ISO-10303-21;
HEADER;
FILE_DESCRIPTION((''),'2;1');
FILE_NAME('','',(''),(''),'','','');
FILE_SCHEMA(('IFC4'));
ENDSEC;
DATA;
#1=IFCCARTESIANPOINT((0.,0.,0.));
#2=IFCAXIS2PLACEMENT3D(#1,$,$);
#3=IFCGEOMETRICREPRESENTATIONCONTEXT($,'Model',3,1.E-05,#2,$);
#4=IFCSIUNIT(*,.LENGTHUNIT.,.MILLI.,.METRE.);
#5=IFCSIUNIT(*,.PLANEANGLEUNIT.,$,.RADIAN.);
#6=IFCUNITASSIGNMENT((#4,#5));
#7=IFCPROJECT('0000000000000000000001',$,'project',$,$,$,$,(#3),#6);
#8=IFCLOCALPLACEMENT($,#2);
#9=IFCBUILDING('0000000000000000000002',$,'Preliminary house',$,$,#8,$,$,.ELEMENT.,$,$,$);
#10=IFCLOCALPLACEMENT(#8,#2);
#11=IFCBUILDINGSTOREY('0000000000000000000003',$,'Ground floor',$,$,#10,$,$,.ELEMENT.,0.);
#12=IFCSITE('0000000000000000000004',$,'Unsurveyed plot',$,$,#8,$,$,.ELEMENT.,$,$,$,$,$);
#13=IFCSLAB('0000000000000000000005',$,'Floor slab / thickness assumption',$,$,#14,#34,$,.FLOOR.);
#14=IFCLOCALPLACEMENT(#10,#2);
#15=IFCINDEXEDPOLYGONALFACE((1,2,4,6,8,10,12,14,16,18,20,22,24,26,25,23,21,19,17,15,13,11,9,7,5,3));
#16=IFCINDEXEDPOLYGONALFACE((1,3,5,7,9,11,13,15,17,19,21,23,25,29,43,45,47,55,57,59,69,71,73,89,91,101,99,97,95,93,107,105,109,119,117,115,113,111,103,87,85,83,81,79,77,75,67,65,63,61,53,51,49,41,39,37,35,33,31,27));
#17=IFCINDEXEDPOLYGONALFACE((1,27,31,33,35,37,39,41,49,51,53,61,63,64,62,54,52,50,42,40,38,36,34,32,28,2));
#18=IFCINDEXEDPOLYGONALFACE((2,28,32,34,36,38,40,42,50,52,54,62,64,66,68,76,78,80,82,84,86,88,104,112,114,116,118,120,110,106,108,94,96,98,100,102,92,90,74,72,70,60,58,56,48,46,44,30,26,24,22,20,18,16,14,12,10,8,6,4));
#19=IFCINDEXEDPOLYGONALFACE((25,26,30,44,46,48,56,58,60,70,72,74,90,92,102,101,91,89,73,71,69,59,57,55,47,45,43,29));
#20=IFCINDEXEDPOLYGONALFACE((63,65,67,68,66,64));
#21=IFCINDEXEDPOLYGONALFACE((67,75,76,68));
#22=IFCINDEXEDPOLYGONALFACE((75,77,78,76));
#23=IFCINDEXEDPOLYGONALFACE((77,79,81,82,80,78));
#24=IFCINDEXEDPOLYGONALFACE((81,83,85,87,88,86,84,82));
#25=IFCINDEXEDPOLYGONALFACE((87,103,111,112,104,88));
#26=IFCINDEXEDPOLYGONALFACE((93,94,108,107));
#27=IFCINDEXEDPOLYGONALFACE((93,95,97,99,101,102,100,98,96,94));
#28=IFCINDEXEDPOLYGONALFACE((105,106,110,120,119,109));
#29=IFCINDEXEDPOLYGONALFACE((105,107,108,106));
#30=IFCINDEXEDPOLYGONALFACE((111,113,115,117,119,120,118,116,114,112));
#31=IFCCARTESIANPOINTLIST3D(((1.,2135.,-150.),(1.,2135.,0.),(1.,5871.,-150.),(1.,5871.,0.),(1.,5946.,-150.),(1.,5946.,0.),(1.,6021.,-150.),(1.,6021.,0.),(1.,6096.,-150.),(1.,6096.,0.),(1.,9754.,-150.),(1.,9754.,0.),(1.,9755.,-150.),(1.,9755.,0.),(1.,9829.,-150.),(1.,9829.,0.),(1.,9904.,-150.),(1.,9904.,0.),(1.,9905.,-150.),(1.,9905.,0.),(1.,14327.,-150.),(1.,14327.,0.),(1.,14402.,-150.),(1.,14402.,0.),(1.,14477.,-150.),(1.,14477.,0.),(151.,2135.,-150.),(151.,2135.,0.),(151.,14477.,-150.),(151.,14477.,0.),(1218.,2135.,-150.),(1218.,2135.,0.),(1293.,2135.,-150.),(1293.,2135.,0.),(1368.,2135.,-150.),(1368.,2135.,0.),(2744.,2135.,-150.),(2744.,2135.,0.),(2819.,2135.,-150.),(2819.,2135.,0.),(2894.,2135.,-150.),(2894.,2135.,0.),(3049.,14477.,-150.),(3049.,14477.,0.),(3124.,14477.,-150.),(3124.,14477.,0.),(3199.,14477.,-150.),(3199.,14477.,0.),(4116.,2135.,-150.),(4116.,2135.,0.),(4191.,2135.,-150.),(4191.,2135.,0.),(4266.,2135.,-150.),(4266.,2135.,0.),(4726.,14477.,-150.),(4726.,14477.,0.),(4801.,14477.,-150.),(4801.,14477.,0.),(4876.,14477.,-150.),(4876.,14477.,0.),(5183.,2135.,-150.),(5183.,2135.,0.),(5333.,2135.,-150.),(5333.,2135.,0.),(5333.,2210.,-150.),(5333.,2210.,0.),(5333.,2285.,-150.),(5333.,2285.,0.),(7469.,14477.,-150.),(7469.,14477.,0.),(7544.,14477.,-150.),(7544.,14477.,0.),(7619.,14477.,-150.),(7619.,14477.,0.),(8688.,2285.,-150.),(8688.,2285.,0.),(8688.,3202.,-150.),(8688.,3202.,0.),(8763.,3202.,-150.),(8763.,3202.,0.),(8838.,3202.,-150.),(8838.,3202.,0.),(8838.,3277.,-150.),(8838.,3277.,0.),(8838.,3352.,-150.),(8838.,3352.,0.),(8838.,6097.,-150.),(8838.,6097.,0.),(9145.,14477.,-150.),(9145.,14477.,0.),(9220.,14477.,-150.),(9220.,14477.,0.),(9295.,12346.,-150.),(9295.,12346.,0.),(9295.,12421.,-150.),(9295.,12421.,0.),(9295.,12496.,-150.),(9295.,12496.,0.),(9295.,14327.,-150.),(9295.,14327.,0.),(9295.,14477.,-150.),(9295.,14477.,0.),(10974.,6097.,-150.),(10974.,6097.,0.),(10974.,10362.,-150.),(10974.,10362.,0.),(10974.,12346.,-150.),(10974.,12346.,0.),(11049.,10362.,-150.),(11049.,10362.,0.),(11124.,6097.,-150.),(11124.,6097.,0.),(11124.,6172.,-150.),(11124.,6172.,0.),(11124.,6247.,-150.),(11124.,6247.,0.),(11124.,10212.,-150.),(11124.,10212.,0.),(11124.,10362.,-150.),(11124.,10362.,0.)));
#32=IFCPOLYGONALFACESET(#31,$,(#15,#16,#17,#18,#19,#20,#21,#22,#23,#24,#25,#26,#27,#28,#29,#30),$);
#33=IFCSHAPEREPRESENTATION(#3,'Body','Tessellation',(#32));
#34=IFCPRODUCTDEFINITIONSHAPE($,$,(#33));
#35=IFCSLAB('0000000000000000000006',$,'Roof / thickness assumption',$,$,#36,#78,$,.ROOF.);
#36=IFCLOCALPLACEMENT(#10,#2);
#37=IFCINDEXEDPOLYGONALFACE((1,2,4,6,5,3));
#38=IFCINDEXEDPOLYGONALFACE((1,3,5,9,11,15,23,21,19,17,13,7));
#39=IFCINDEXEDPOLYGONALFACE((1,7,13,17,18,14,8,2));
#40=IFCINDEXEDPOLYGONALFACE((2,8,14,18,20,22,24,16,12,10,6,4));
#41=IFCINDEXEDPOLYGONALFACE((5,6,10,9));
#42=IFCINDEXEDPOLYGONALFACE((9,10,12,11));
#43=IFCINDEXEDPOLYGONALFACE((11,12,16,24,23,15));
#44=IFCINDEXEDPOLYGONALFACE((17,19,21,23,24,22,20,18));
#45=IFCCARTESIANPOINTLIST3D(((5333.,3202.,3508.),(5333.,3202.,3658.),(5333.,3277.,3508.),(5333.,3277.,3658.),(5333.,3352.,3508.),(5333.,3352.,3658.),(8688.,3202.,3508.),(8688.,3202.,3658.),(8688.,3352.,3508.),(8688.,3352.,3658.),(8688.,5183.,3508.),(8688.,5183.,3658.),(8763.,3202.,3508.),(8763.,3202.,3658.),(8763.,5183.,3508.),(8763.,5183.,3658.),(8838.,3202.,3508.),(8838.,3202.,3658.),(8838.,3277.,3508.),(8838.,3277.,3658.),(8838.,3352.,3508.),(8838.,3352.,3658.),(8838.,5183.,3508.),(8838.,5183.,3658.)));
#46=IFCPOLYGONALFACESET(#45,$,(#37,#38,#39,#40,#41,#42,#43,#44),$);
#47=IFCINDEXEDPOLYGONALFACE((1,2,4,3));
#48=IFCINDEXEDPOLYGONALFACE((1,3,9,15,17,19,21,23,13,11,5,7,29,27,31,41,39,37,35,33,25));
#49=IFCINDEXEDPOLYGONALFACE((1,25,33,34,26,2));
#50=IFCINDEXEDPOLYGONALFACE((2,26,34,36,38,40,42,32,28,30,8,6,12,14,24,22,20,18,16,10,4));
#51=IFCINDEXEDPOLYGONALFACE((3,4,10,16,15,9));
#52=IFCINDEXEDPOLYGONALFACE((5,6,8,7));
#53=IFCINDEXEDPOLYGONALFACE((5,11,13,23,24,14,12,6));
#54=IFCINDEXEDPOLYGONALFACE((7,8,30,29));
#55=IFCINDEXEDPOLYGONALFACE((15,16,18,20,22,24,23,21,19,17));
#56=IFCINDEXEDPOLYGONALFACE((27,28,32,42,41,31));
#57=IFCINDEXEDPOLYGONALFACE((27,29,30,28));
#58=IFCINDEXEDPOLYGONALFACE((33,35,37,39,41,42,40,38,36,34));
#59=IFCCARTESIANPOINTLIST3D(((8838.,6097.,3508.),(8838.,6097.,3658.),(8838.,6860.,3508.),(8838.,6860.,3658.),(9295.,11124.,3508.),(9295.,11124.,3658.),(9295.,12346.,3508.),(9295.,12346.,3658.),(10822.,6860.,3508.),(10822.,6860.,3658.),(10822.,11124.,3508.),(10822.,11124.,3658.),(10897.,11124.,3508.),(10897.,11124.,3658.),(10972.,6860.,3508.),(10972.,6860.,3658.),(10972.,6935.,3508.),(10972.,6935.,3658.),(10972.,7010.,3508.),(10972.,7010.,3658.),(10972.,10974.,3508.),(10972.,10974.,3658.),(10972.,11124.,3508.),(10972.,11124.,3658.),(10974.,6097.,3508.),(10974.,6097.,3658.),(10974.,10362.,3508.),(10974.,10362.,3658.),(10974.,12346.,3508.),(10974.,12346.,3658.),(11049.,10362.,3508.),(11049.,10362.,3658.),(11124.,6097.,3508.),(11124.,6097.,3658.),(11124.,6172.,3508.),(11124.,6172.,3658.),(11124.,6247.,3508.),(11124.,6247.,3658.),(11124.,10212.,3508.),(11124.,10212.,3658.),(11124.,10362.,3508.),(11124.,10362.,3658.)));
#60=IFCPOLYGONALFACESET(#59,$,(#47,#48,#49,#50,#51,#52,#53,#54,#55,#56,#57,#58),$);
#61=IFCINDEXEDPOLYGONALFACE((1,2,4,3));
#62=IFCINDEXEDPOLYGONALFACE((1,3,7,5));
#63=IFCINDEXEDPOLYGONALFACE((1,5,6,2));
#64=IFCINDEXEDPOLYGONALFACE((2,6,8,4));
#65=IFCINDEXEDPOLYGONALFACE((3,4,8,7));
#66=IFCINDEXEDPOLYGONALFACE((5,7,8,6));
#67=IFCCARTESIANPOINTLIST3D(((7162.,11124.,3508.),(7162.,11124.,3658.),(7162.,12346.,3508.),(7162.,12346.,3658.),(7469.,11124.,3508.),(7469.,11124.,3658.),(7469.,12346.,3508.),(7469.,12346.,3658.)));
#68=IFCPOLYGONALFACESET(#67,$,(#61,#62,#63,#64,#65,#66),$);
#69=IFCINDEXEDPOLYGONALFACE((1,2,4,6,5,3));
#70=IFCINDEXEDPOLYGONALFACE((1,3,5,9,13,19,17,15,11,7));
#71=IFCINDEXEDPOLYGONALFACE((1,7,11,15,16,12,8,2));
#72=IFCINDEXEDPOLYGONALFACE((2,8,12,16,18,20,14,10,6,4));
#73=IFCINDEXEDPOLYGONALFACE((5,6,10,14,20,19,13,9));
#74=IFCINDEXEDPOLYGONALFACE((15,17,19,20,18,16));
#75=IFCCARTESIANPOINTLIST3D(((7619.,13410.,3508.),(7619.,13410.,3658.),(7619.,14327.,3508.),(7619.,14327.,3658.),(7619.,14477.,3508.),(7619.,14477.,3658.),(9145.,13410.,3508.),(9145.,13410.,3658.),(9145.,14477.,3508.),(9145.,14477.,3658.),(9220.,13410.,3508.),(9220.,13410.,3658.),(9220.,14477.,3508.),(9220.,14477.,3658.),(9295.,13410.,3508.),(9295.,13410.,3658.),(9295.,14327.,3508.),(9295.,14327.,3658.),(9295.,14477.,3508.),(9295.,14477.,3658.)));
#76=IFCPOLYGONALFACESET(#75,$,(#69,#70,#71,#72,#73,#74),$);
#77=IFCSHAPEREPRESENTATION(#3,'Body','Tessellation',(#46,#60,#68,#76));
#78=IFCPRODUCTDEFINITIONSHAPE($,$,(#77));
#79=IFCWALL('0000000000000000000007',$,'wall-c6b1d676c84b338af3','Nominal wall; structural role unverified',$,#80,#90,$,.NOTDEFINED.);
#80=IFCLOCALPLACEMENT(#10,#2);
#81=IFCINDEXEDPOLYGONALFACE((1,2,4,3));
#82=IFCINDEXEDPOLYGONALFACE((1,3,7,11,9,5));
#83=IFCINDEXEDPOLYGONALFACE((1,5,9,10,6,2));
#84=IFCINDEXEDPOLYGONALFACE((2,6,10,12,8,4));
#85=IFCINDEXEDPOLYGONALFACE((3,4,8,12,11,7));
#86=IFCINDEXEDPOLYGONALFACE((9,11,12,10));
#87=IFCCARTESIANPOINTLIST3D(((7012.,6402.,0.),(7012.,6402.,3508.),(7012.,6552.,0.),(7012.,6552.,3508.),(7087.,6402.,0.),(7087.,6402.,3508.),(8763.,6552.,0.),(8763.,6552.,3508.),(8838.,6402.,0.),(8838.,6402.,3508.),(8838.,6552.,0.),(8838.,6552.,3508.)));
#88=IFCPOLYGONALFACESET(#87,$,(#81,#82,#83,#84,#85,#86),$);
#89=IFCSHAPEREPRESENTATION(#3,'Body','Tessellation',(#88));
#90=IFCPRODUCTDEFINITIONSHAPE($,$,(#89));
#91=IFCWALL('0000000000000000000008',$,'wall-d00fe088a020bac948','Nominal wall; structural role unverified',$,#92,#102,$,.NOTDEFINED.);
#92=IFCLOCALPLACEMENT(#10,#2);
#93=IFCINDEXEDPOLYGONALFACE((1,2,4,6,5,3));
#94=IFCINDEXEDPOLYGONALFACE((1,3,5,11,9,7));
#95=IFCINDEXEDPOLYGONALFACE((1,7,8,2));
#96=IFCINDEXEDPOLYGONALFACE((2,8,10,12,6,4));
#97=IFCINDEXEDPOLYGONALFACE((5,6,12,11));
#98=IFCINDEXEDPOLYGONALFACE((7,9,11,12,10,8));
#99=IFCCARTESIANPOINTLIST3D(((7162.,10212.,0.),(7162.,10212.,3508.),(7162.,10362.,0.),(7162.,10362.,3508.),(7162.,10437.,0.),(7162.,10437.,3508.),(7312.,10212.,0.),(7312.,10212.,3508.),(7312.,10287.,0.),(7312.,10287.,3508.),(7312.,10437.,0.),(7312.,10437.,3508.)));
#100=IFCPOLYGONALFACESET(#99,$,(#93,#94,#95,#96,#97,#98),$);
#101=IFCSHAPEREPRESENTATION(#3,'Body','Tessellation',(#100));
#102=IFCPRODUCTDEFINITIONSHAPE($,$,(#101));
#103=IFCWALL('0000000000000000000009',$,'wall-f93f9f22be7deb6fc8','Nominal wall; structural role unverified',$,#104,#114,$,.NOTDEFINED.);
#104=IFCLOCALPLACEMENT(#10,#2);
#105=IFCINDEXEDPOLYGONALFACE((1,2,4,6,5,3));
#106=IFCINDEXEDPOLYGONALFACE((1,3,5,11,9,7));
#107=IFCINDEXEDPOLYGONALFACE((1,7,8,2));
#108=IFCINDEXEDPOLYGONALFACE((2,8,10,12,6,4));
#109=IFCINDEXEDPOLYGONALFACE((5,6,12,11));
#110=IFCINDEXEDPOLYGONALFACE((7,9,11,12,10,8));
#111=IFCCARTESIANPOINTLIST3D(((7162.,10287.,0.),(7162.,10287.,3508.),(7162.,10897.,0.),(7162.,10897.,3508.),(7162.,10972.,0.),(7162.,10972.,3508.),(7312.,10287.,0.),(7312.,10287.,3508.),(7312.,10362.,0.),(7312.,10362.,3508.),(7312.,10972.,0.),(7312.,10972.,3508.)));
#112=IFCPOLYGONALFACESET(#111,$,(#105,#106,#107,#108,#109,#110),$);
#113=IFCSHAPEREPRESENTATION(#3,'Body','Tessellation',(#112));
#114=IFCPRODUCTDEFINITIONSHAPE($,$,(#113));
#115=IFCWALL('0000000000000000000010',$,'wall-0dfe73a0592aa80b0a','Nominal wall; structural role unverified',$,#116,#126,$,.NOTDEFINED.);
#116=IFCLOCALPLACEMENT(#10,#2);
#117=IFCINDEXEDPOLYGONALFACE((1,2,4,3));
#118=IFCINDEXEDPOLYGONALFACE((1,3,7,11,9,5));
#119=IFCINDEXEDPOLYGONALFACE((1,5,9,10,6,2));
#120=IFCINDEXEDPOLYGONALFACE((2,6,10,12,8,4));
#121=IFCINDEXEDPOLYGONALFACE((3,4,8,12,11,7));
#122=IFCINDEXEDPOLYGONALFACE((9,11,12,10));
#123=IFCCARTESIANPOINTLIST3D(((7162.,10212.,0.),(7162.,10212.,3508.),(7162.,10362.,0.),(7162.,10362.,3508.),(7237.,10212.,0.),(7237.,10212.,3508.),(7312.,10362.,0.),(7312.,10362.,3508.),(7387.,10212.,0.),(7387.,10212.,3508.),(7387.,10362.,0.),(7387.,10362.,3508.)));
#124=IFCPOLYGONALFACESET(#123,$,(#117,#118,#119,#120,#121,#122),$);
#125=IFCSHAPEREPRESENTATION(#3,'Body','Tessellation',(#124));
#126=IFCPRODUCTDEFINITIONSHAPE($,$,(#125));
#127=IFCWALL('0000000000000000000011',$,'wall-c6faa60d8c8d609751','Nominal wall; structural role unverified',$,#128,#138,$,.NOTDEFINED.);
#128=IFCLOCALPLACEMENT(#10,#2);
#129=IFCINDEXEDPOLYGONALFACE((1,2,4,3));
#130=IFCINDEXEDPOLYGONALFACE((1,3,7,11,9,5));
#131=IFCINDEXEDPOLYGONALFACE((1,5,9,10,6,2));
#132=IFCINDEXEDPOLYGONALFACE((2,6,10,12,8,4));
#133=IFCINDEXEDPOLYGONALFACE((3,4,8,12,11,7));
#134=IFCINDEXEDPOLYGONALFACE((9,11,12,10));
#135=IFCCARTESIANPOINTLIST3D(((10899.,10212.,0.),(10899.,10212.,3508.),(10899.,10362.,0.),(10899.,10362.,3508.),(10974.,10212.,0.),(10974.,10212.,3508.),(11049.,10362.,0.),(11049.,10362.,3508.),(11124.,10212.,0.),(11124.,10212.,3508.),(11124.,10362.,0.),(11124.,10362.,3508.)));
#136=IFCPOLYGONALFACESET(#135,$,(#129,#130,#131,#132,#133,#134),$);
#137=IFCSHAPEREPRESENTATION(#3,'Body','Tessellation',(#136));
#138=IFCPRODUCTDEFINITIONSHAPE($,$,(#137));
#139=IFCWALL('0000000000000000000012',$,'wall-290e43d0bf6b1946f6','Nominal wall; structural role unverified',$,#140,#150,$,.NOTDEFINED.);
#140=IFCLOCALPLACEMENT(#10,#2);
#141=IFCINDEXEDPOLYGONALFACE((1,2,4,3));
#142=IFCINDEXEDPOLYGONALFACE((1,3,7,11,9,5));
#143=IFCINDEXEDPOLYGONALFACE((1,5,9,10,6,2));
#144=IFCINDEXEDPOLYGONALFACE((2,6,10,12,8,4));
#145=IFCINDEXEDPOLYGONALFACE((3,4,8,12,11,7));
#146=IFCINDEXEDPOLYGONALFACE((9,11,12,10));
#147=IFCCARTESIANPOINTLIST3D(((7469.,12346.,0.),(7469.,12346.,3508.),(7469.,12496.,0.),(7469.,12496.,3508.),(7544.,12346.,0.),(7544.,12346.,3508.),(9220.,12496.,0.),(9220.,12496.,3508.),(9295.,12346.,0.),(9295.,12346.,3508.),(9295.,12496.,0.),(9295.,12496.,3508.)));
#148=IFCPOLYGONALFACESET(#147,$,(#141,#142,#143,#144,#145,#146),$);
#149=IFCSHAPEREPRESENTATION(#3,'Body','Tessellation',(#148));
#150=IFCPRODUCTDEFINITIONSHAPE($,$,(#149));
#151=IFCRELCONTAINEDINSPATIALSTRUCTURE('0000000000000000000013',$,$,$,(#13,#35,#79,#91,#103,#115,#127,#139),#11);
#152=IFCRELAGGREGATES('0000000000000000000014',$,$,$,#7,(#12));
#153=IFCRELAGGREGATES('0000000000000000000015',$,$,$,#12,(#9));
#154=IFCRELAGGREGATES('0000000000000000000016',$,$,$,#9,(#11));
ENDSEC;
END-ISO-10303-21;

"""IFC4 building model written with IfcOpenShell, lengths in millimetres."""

from ifc_helpers import new_model, si_unit, frame, origin, place, context, project, spatial, polyline, outline, extrude, element, save


model = new_model("IFC4")

# Units and contexts
model_context = context("Model", 3, precision=1e-05, world=origin())
ifc_project = project(units=[si_unit("LENGTHUNIT", "METRE", prefix="MILLI"), si_unit("PLANEANGLEUNIT", "RADIAN")], contexts=[model_context])

# Site, building, storey
placement_1 = place(None, origin())
site = spatial("IfcSite", under=ifc_project, at=placement_1, Name="Unsurveyed plot", CompositionType="ELEMENT")
building = spatial("IfcBuilding", under=site, at=placement_1, Name="Preliminary house", CompositionType="ELEMENT")
placement_2 = place(placement_1, origin())
storey = spatial("IfcBuildingStorey", under=building, at=placement_2, Name="Ground floor", CompositionType="ELEMENT", Elevation=0.0)

# Slabs
element("IfcSlab", 1, at=placement_2, inside=storey, Name="Floor slab / thickness assumption", PredefinedType="FLOOR", context=model_context, shape_type="SweptSolid", body=[
    extrude(outline(polyline([(1368.0, 2135.0), (1293.0, 2135.0), (1218.0, 2135.0), (151.0, 2135.0), (1.0, 2135.0), (1.0, 5871.0), (1.0, 5946.0), (1.0, 6021.0), (1.0, 6096.0), (1.0, 9754.0), (1.0, 9755.0), (1.0, 9829.0), (1.0, 9904.0), (1.0, 9905.0), (1.0, 14327.0), (1.0, 14402.0), (1.0, 14477.0), (151.0, 14477.0), (3049.0, 14477.0), (3124.0, 14477.0), (3199.0, 14477.0), (4726.0, 14477.0), (4801.0, 14477.0), (4876.0, 14477.0), (7469.0, 14477.0), (7544.0, 14477.0), (7619.0, 14477.0), (9145.0, 14477.0), (9220.0, 14477.0), (9295.0, 14477.0), (9295.0, 14327.0), (9295.0, 12496.0), (9295.0, 12421.0), (9295.0, 12346.0), (10974.0, 12346.0), (10974.0, 10362.0), (11049.0, 10362.0), (11124.0, 10362.0), (11124.0, 10212.0), (11124.0, 6247.0), (11124.0, 6172.0), (11124.0, 6097.0), (10974.0, 6097.0), (8838.0, 6097.0), (8838.0, 3352.0), (8838.0, 3277.0), (8838.0, 3202.0), (8763.0, 3202.0), (8688.0, 3202.0), (8688.0, 2285.0), (5333.0, 2285.0), (5333.0, 2210.0), (5333.0, 2135.0), (5183.0, 2135.0), (4266.0, 2135.0), (4191.0, 2135.0), (4116.0, 2135.0), (2894.0, 2135.0), (2819.0, 2135.0), (2744.0, 2135.0), (1368.0, 2135.0)])), frame((0.0, 0.0, -150.0)), (0.0, 0.0, 1.0), 150.0),
])
element("IfcSlab", 2, at=placement_2, inside=storey, Name="Roof / thickness assumption", PredefinedType="ROOF", context=model_context, shape_type="SweptSolid", body=[
    extrude(outline(polyline([(8838.0, 3202.0), (8763.0, 3202.0), (8688.0, 3202.0), (5333.0, 3202.0), (5333.0, 3277.0), (5333.0, 3352.0), (8688.0, 3352.0), (8688.0, 5183.0), (8763.0, 5183.0), (8838.0, 5183.0), (8838.0, 3352.0), (8838.0, 3277.0), (8838.0, 3202.0)])), frame((0.0, 0.0, 3508.0)), (0.0, 0.0, 1.0), 150.0),
    extrude(outline(polyline([(11049.0, 10362.0), (11124.0, 10362.0), (11124.0, 10212.0), (11124.0, 6247.0), (11124.0, 6172.0), (11124.0, 6097.0), (10974.0, 6097.0), (8838.0, 6097.0), (8838.0, 6860.0), (10822.0, 6860.0), (10972.0, 6860.0), (10972.0, 6935.0), (10972.0, 7010.0), (10972.0, 10974.0), (10972.0, 11124.0), (10897.0, 11124.0), (10822.0, 11124.0), (9295.0, 11124.0), (9295.0, 12346.0), (10974.0, 12346.0), (10974.0, 10362.0), (11049.0, 10362.0)])), frame((0.0, 0.0, 3508.0)), (0.0, 0.0, 1.0), 150.0),
    extrude(outline(polyline([(7162.0, 11124.0), (7162.0, 12346.0), (7469.0, 12346.0), (7469.0, 11124.0), (7162.0, 11124.0)])), frame((0.0, 0.0, 3508.0)), (0.0, 0.0, 1.0), 150.0),
    extrude(outline(polyline([(9295.0, 14477.0), (9295.0, 14327.0), (9295.0, 13410.0), (9220.0, 13410.0), (9145.0, 13410.0), (7619.0, 13410.0), (7619.0, 14327.0), (7619.0, 14477.0), (9145.0, 14477.0), (9220.0, 14477.0), (9295.0, 14477.0)])), frame((0.0, 0.0, 3508.0)), (0.0, 0.0, 1.0), 150.0),
])

# Walls
element("IfcWall", 3, at=placement_2, inside=storey, Name="wall-c6b1d676c84b338af3", Description="Nominal wall; structural role unverified", PredefinedType="NOTDEFINED", context=model_context, shape_type="SweptSolid", body=[
    extrude(outline(polyline([(8763.0, 6552.0), (8838.0, 6552.0), (8838.0, 6402.0), (7087.0, 6402.0), (7012.0, 6402.0), (7012.0, 6552.0), (8763.0, 6552.0)])), origin(), (0.0, 0.0, 1.0), 3508.0),
])
element("IfcWall", 4, at=placement_2, inside=storey, Name="wall-d00fe088a020bac948", Description="Nominal wall; structural role unverified", PredefinedType="NOTDEFINED", context=model_context, shape_type="SweptSolid", body=[
    extrude(outline(polyline([(7162.0, 10362.0), (7162.0, 10437.0), (7312.0, 10437.0), (7312.0, 10287.0), (7312.0, 10212.0), (7162.0, 10212.0), (7162.0, 10362.0)])), origin(), (0.0, 0.0, 1.0), 3508.0),
])
element("IfcWall", 5, at=placement_2, inside=storey, Name="wall-f93f9f22be7deb6fc8", Description="Nominal wall; structural role unverified", PredefinedType="NOTDEFINED", context=model_context, shape_type="SweptSolid", body=[
    extrude(outline(polyline([(7162.0, 10897.0), (7162.0, 10972.0), (7312.0, 10972.0), (7312.0, 10362.0), (7312.0, 10287.0), (7162.0, 10287.0), (7162.0, 10897.0)])), origin(), (0.0, 0.0, 1.0), 3508.0),
])
element("IfcWall", 6, at=placement_2, inside=storey, Name="wall-0dfe73a0592aa80b0a", Description="Nominal wall; structural role unverified", PredefinedType="NOTDEFINED", context=model_context, shape_type="SweptSolid", body=[
    extrude(outline(polyline([(7312.0, 10362.0), (7387.0, 10362.0), (7387.0, 10212.0), (7237.0, 10212.0), (7162.0, 10212.0), (7162.0, 10362.0), (7312.0, 10362.0)])), origin(), (0.0, 0.0, 1.0), 3508.0),
])

# Wall
element("IfcWall", 7, at=placement_2, inside=storey, Name="wall-c6faa60d8c8d609751", Description="Nominal wall; structural role unverified", PredefinedType="NOTDEFINED", context=model_context, shape_type="SweptSolid", body=[
    extrude(outline(polyline([(11049.0, 10362.0), (11124.0, 10362.0), (11124.0, 10212.0), (10974.0, 10212.0), (10899.0, 10212.0), (10899.0, 10362.0), (11049.0, 10362.0)])), origin(), (0.0, 0.0, 1.0), 3508.0),
])

# Wall
element("IfcWall", 8, at=placement_2, inside=storey, Name="wall-290e43d0bf6b1946f6", Description="Nominal wall; structural role unverified", PredefinedType="NOTDEFINED", context=model_context, shape_type="SweptSolid", body=[
    extrude(outline(polyline([(9220.0, 12496.0), (9295.0, 12496.0), (9295.0, 12346.0), (7544.0, 12346.0), (7469.0, 12346.0), (7469.0, 12496.0), (9220.0, 12496.0)])), origin(), (0.0, 0.0, 1.0), 3508.0),
])

save(model, "model.ifc")
